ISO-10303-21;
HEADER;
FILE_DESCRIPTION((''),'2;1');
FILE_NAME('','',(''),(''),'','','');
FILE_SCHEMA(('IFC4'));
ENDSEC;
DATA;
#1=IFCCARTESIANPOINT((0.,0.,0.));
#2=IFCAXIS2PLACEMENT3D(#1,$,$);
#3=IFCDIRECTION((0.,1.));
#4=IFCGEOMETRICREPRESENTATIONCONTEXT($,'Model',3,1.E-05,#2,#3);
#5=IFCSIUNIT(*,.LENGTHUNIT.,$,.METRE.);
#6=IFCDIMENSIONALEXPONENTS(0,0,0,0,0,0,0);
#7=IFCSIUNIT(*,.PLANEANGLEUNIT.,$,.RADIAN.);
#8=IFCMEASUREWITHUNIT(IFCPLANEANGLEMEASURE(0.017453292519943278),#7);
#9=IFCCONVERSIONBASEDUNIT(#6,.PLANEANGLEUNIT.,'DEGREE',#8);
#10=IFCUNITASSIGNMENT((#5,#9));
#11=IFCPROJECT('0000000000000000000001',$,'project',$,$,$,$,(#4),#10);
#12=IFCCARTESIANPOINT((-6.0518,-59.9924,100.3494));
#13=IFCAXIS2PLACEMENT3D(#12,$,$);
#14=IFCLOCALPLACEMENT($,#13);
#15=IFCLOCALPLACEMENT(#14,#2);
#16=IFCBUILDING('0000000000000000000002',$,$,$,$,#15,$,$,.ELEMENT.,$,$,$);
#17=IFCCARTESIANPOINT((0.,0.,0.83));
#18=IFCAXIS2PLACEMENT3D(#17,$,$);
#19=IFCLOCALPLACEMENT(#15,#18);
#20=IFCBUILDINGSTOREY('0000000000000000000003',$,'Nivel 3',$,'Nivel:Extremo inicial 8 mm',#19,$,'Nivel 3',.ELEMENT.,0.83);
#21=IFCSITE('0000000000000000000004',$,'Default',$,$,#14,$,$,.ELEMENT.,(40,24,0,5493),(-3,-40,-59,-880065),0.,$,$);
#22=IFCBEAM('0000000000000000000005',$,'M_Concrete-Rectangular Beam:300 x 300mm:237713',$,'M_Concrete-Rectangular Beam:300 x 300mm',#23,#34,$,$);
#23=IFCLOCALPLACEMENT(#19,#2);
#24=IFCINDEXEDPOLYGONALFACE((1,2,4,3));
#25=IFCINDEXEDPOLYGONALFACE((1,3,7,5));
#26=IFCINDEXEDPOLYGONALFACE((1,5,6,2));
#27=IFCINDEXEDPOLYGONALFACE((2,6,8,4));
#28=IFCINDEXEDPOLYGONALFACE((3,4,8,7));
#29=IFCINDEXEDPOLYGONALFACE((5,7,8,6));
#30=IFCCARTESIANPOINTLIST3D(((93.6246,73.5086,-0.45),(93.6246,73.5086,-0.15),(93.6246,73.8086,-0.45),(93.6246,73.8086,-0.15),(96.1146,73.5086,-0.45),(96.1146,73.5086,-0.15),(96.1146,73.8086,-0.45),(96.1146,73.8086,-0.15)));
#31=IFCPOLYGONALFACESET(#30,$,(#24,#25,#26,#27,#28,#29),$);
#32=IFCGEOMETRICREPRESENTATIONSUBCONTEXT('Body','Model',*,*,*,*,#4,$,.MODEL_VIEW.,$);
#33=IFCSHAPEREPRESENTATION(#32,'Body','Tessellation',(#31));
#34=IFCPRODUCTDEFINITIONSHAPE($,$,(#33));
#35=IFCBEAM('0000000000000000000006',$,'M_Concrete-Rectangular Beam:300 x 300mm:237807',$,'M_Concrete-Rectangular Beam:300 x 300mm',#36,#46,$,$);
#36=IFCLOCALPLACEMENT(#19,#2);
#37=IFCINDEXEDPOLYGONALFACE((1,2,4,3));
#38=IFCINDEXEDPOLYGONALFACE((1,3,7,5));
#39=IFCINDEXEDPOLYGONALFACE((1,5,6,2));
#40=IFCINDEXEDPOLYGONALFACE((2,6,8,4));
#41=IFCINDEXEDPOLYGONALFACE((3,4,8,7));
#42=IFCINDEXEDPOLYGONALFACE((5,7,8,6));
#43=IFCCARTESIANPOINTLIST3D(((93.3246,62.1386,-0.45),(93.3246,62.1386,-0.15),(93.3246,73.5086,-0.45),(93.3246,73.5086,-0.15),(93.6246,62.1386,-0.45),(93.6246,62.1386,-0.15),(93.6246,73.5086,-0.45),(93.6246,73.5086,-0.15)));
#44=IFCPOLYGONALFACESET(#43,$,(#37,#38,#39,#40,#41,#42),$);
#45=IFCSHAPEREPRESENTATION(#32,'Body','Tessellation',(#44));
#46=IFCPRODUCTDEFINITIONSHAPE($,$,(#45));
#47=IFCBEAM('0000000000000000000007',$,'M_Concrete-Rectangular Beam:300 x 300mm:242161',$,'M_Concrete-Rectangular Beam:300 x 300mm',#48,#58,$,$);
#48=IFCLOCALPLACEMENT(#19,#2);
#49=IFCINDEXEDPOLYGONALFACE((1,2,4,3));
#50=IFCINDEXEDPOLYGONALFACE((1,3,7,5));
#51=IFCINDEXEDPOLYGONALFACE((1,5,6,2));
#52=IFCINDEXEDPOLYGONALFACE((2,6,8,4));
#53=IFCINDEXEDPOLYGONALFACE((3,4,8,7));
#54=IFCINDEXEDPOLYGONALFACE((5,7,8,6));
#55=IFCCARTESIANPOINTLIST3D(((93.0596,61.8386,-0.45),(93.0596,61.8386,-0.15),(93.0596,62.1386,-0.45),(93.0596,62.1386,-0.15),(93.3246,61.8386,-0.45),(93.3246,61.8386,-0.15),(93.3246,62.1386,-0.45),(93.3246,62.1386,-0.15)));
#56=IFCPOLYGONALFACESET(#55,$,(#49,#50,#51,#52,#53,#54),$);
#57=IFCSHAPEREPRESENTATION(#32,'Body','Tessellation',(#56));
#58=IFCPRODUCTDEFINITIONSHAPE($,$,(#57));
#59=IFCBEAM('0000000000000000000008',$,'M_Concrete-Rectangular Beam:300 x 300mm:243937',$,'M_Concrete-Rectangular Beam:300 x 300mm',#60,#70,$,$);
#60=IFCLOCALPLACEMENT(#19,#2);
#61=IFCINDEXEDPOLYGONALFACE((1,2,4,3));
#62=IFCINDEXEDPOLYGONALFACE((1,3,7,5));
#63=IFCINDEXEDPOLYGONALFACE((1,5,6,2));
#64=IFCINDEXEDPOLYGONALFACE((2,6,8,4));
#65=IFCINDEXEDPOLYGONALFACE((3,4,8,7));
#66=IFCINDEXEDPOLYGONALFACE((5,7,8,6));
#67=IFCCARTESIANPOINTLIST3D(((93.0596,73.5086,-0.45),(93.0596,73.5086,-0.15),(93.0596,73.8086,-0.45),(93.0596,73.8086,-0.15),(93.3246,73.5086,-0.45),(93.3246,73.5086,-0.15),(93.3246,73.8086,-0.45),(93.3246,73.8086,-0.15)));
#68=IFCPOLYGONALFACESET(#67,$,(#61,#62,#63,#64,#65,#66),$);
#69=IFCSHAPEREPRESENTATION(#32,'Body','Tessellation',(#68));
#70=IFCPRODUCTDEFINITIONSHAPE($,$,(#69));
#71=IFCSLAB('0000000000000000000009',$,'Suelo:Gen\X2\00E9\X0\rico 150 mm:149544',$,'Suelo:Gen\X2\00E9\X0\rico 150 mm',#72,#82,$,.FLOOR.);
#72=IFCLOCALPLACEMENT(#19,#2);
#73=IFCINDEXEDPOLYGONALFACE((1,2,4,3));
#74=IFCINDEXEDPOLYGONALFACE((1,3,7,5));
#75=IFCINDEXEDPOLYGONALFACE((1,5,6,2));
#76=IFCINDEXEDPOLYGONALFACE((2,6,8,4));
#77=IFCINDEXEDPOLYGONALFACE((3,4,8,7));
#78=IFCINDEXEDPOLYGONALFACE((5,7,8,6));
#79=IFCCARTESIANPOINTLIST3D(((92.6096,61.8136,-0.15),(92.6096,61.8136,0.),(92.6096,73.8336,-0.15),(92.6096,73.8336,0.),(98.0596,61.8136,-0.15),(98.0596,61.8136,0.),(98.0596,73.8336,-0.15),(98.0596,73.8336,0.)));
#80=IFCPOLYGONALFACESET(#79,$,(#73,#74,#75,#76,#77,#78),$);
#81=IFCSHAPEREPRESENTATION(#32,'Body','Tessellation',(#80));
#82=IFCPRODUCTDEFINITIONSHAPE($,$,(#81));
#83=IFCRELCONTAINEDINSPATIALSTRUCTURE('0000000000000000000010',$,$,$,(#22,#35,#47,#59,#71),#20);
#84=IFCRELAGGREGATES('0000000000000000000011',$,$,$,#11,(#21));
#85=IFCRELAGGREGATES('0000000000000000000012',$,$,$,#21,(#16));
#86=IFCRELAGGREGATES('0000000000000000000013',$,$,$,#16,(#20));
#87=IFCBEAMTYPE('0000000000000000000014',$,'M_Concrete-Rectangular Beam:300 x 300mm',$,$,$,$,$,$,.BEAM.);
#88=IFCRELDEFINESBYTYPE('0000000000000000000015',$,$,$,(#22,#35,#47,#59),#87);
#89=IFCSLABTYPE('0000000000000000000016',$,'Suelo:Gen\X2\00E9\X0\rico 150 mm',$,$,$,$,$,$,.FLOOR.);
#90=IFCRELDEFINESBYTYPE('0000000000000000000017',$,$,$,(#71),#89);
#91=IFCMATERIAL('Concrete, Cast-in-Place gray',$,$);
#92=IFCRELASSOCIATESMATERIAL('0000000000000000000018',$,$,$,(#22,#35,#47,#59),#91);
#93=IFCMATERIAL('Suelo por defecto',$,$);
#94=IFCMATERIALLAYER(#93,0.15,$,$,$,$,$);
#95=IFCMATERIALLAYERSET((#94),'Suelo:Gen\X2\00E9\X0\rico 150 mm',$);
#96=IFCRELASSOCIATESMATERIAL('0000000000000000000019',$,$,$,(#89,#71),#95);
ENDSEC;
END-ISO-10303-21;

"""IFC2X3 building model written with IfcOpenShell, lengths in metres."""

from ifc_helpers import new_model, entity, si_unit, converted_unit, direction, frame, frame_2d, origin, place, context, subcontext, project, spatial, rectangle, extrude, material, layer, layer_set, layer_usage, type_object, element, save


model = new_model("IFC2X3")

# Units and contexts
model_context = context("Model", 3, precision=1e-05, world=origin(), true_north=direction((0.0, 1.0)))
body_context = subcontext(model_context, "Body", "Model", "MODEL_VIEW")
ifc_project = project(units=[si_unit("LENGTHUNIT", "METRE"), converted_unit("PLANEANGLEUNIT", "DEGREE", entity("IfcPlaneAngleMeasure", 0.017453292519943278), si_unit("PLANEANGLEUNIT", "RADIAN"), dimensions=[0, 0, 0, 0, 0, 0, 0])], contexts=[model_context])

# Site, building, storey
site_placement = place(None, frame((-6.0518, -59.9924, 100.3494)))
site = spatial("IfcSite", under=ifc_project, at=site_placement, Name="Default", CompositionType="ELEMENT", RefLatitude=(40, 24, 0, 5493), RefLongitude=(-3, -40, -59, -880065), RefElevation=0.0)
building_placement = place(site_placement, origin())
building = spatial("IfcBuilding", under=site, at=building_placement, CompositionType="ELEMENT")
storey_placement = place(building_placement, frame((0.0, 0.0, 0.83)))
storey = spatial("IfcBuildingStorey", under=building, at=storey_placement, Name="Nivel 3", ObjectType="Nivel:Extremo inicial 8 mm", LongName="Nivel 3", CompositionType="ELEMENT", Elevation=0.83)

# Shared definitions
ifc_material_1 = material(Name="Concrete, Cast-in-Place gray")

# Beams
beam_type = type_object("IfcBeamType", Name="M_Concrete-Rectangular Beam:300 x 300mm", PredefinedType="BEAM")
beam_1_placement = place(storey_placement, frame((93.4746, 73.6586, 0.0)))
element("IfcBeam", 1, at=beam_1_placement, inside=storey, type_object=beam_type, material=ifc_material_1, Name="M_Concrete-Rectangular Beam:300 x 300mm:237713", ObjectType="M_Concrete-Rectangular Beam:300 x 300mm", context=body_context, shape_type="SweptSolid", body=[
    extrude(rectangle(XDim=0.3, YDim=0.3, at=frame_2d((0.0, 0.0), x_axis=(1.0, 0.0))), frame((0.15, 0.0, -0.3), z_axis=(1.0, 0.0, 0.0), x_axis=(0.0, 0.0, -1.0)), (0.0, 0.0, 1.0), 2.49),
])
beam_2_placement = place(storey_placement, frame((93.4746, 61.9886, 0.0), z_axis=(0.0, 0.0, 1.0), x_axis=(0.0, 1.0, 0.0)))
element("IfcBeam", 2, at=beam_2_placement, inside=storey, type_object=beam_type, material=ifc_material_1, Name="M_Concrete-Rectangular Beam:300 x 300mm:237807", ObjectType="M_Concrete-Rectangular Beam:300 x 300mm", context=body_context, shape_type="SweptSolid", body=[
    extrude(rectangle(XDim=0.3, YDim=0.3, at=frame_2d((0.0, 0.0), x_axis=(1.0, 0.0))), frame((0.15, 0.0, -0.3), z_axis=(1.0, 0.0, 0.0), x_axis=(0.0, 0.0, -1.0)), (0.0, 0.0, 1.0), 11.37),
])
beam_3_placement = place(storey_placement, frame((93.4746, 61.9886, 0.0), z_axis=(0.0, 0.0, 1.0), x_axis=(-1.0, 0.0, 0.0)))
element("IfcBeam", 3, at=beam_3_placement, inside=storey, type_object=beam_type, material=ifc_material_1, Name="M_Concrete-Rectangular Beam:300 x 300mm:242161", ObjectType="M_Concrete-Rectangular Beam:300 x 300mm", context=body_context, shape_type="SweptSolid", body=[
    extrude(rectangle(XDim=0.3, YDim=0.3, at=frame_2d((0.0, 0.0), x_axis=(1.0, 0.0))), frame((0.15, 0.0, -0.3), z_axis=(1.0, 0.0, 0.0), x_axis=(0.0, 0.0, -1.0)), (0.0, 0.0, 1.0), 0.265),
])
beam_4_placement = place(storey_placement, frame((93.4746, 73.6586, 0.0), z_axis=(0.0, 0.0, 1.0), x_axis=(-1.0, 0.0, 0.0)))
element("IfcBeam", 4, at=beam_4_placement, inside=storey, type_object=beam_type, material=ifc_material_1, Name="M_Concrete-Rectangular Beam:300 x 300mm:243937", ObjectType="M_Concrete-Rectangular Beam:300 x 300mm", context=body_context, shape_type="SweptSolid", body=[
    extrude(rectangle(XDim=0.3, YDim=0.3, at=frame_2d((0.0, 0.0), x_axis=(1.0, 0.0))), frame((0.15, 0.0, -0.3), z_axis=(1.0, 0.0, 0.0), x_axis=(0.0, 0.0, -1.0)), (0.0, 0.0, 1.0), 0.265),
])

# Slab
ifc_material_2 = material(Name="Suelo por defecto")
ifc_layer = layer(ifc_material_2, 0.15)
ifc_layer_set = layer_set([ifc_layer], Name="Suelo:Genérico 150 mm")
ifc_layer_usage = layer_usage(ifc_layer_set, "AXIS3", "POSITIVE", 0.0)
slab_type = type_object("IfcSlabType", Name="Suelo:Genérico 150 mm", PredefinedType="FLOOR", material=ifc_layer_set)
slab_placement = place(storey_placement, origin())
element("IfcSlab", 5, at=slab_placement, inside=storey, type_object=slab_type, material=ifc_layer_usage, Name="Suelo:Genérico 150 mm:149544", ObjectType="Suelo:Genérico 150 mm", PredefinedType="FLOOR", context=body_context, shape_type="SweptSolid", body=[
    extrude(rectangle(XDim=12.02, YDim=5.45, at=frame_2d((0.0, 0.0), x_axis=(1.0, 0.0))), frame((95.3346, 67.8236, 0.0), z_axis=(0.0, 0.0, -1.0), x_axis=(0.0, 1.0, 0.0)), (0.0, 0.0, 1.0), 0.15),
])

save(model, "model.ifc")
